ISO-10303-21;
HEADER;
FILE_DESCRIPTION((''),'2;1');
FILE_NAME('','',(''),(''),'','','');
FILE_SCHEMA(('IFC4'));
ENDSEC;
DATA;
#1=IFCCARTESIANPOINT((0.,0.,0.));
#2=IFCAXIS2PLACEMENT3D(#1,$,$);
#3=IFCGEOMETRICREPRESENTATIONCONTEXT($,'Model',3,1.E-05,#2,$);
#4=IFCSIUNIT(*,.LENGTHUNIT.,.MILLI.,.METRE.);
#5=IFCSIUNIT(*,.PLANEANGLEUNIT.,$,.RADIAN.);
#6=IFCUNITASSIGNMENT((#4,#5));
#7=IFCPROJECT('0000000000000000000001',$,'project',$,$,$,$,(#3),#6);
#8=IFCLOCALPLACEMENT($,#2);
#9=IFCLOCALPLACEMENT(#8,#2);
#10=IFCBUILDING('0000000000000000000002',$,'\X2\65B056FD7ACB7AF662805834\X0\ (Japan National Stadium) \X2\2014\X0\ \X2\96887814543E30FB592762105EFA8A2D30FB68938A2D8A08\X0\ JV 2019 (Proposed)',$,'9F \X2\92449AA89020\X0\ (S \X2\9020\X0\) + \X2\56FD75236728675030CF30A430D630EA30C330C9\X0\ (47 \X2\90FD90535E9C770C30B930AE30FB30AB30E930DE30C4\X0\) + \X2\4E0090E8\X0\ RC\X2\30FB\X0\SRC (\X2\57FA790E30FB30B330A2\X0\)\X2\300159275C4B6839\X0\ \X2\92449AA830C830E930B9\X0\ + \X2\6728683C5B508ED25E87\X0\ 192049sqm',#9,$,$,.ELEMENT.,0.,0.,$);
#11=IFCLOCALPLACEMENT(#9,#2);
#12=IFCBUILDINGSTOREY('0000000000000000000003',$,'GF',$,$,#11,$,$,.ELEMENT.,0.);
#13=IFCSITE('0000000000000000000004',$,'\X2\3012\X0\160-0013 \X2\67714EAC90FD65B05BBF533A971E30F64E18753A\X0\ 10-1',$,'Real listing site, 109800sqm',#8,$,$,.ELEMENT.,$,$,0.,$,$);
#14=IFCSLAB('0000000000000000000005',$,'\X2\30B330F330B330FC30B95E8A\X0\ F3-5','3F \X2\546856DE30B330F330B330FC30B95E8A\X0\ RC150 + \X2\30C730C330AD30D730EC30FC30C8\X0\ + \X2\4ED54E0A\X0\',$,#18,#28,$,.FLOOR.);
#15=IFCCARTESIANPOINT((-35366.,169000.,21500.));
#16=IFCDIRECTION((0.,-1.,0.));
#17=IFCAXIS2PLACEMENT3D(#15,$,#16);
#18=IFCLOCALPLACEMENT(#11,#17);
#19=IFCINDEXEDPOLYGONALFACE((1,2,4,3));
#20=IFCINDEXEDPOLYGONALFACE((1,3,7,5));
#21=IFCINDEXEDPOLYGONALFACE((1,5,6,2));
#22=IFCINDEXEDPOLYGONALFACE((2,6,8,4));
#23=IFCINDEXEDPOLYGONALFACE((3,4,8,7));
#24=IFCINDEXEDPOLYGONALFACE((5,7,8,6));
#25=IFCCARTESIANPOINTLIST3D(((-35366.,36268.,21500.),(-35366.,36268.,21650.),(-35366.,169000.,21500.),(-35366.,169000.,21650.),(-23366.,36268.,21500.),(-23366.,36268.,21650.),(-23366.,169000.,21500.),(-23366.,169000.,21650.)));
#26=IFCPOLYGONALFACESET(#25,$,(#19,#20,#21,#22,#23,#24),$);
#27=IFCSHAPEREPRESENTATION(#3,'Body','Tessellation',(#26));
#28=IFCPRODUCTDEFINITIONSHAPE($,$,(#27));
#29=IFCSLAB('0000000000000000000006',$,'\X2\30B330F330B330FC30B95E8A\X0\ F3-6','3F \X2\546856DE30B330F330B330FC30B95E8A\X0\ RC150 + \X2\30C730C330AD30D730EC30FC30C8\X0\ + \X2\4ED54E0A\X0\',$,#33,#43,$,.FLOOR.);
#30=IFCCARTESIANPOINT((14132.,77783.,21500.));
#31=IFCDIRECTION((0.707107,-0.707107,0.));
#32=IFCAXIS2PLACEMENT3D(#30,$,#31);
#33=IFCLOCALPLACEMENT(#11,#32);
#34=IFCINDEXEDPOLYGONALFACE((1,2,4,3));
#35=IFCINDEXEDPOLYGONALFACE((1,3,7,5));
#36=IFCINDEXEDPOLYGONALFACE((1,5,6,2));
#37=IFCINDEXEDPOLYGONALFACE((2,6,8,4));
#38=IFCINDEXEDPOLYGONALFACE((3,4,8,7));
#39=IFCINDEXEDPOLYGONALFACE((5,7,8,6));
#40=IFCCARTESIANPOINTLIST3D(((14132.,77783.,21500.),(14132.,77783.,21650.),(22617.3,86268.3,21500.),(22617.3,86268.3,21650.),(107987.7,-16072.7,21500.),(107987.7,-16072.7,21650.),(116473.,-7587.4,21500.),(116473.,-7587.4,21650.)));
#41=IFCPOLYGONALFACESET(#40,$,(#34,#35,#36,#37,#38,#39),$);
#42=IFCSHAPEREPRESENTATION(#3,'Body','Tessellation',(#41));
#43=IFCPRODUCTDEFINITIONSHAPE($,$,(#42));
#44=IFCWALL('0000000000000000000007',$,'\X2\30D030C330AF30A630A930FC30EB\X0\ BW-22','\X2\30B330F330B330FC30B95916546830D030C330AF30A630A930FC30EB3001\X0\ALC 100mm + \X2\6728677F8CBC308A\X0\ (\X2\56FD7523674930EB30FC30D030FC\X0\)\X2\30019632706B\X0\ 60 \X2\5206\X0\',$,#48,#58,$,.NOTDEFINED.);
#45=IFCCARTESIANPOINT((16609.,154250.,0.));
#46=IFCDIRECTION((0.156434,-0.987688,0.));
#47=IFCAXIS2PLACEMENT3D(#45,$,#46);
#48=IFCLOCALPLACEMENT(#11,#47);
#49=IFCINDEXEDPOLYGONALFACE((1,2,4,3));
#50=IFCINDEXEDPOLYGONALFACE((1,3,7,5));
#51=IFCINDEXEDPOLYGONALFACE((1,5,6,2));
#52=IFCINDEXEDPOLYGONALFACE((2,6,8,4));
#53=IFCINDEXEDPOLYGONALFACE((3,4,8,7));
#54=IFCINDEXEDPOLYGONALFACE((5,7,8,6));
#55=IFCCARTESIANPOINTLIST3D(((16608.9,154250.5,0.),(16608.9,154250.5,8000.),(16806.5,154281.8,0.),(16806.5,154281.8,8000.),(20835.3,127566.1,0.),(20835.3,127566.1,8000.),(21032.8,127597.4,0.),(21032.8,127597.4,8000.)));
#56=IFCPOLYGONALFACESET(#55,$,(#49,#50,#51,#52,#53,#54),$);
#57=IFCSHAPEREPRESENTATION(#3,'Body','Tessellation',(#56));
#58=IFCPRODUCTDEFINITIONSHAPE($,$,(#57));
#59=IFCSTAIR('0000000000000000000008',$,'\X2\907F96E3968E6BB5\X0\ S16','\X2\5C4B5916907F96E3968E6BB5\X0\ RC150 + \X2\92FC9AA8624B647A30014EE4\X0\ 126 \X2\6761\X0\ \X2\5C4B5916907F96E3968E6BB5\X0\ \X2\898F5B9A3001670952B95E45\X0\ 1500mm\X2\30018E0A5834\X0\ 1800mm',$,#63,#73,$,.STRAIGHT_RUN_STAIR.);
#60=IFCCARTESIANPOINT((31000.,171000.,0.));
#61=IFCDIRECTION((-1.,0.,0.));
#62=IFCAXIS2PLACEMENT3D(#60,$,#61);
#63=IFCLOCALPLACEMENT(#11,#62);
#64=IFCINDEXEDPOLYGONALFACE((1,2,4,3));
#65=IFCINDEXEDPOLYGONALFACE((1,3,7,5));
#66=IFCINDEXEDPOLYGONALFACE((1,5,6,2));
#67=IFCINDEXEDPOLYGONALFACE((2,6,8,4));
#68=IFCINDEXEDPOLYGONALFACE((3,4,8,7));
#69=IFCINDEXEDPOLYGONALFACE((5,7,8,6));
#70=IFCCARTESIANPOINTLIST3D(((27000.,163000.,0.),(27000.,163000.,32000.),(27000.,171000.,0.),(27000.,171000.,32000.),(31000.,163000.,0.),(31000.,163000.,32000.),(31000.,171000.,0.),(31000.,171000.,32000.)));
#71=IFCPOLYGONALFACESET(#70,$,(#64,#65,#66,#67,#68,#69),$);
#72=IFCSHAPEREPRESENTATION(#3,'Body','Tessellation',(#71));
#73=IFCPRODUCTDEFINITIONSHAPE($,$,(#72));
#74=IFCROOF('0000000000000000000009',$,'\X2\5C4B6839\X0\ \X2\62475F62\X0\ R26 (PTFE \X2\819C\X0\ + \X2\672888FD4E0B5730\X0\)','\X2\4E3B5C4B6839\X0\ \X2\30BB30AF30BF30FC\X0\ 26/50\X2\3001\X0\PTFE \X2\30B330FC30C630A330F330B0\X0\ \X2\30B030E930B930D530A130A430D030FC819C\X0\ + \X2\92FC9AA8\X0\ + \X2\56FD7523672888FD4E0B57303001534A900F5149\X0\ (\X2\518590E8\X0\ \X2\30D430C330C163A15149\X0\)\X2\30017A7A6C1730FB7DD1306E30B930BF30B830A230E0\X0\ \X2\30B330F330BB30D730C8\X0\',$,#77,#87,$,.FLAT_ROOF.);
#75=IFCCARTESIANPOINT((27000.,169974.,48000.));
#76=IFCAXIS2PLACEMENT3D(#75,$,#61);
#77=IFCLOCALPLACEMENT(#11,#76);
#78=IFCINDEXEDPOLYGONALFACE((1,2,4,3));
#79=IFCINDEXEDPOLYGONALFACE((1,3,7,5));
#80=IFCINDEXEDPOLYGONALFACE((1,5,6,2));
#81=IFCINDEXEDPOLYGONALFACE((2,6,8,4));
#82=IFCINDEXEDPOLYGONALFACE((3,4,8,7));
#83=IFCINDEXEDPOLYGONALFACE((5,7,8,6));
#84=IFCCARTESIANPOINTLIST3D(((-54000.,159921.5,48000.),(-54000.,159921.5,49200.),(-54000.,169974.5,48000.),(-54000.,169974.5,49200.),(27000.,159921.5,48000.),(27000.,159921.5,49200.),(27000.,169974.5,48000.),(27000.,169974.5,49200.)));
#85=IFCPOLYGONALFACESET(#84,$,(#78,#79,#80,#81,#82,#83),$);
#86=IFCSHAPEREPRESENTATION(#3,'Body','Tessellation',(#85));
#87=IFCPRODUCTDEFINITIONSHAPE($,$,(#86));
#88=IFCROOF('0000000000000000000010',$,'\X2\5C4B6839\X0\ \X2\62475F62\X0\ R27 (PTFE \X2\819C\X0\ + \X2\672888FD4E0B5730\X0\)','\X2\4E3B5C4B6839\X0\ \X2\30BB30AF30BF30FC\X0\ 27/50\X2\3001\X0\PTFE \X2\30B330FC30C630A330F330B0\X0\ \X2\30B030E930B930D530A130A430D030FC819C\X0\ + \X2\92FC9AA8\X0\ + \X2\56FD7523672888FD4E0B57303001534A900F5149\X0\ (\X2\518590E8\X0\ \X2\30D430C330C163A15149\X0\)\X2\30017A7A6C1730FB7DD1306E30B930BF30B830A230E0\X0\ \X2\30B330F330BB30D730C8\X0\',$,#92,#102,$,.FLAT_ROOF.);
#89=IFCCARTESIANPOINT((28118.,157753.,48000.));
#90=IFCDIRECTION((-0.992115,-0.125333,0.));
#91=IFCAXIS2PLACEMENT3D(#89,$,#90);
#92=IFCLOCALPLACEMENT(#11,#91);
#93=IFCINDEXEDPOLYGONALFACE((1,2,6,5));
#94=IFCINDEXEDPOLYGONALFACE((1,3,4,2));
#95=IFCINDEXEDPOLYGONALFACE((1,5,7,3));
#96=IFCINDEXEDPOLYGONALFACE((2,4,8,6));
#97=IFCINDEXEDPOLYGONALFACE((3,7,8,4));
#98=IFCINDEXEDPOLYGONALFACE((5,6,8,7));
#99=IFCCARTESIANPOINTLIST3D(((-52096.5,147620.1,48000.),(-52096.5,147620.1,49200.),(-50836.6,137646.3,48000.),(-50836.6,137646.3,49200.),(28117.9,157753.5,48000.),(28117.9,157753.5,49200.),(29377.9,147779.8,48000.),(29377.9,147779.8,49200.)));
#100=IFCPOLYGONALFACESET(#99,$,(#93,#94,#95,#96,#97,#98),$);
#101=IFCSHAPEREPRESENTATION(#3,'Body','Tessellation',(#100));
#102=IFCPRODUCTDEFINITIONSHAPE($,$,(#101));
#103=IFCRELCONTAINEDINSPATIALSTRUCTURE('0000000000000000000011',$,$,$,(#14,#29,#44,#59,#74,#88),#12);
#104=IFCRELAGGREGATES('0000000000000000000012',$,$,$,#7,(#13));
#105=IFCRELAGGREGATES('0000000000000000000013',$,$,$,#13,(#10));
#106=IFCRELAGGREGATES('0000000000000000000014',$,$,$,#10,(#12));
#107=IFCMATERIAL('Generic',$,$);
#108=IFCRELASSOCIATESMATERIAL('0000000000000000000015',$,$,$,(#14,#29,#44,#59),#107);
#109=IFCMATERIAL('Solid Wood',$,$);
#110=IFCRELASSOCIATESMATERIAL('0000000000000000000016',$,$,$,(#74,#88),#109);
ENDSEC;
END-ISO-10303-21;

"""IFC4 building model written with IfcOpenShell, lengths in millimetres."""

from ifc_helpers import new_model, si_unit, frame, frame_2d, origin, place, context, project, spatial, rectangle, extrude, material, element, save


model = new_model("IFC4")

# Units and contexts
model_context = context("Model", 3, precision=1e-05, world=origin())
ifc_project = project(units=[si_unit("LENGTHUNIT", "METRE", prefix="MILLI"), si_unit("PLANEANGLEUNIT", "RADIAN")], contexts=[model_context])

# Site, building, storey
site_placement = place(None, origin())
site = spatial("IfcSite", under=ifc_project, at=site_placement, Name="〒160-0013 東京都新宿区霞ヶ丘町 10-1", ObjectType="Real listing site, 109800sqm", CompositionType="ELEMENT", RefElevation=0.0)
building_placement = place(site_placement, origin())
building = spatial("IfcBuilding", under=site, at=building_placement, Name="新国立競技場 (Japan National Stadium) — 隈研吾・大成建設・梓設計 JV 2019 (Proposed)", ObjectType="9F 鉄骨造 (S 造) + 国産木材ハイブリッド (47 都道府県スギ・カラマツ) + 一部 RC・SRC (基礎・コア)、大屋根 鉄骨トラス + 木格子軒庇 192049sqm", CompositionType="ELEMENT", ElevationOfRefHeight=0.0, ElevationOfTerrain=0.0)
storey_placement = place(building_placement, origin())
storey = spatial("IfcBuildingStorey", under=building, at=storey_placement, Name="GF", CompositionType="ELEMENT", Elevation=0.0)

# Shared definitions
ifc_material_1 = material(Name="Generic")

# Shared definitions
ifc_material_2 = material(Name="Solid Wood")

# Slabs
slab_1_placement = place(storey_placement, frame((-35366.0, 169000.0, 21500.0), x_axis=(0.0, -1.0, 0.0)))
element("IfcSlab", 1, at=slab_1_placement, inside=storey, material=ifc_material_1, Name="コンコース床 F3-5", Description="3F 周回コンコース床 RC150 + デッキプレート + 仕上", PredefinedType="FLOOR", context=model_context, shape_type="SweptSolid", body=[
    extrude(rectangle(XDim=132732.0, YDim=12000.0, at=frame_2d((66366.0, 6000.0))), frame((-35366.0, 169000.0, 21500.0), x_axis=(0.0, -1.0, 0.0)), (0.0, 0.0, 1.0), 150.0),
])
slab_2_placement = place(storey_placement, frame((14132.0, 77783.0, 21500.0), x_axis=(0.707107, -0.707107, 0.0)))
element("IfcSlab", 2, at=slab_2_placement, inside=storey, material=ifc_material_1, Name="コンコース床 F3-6", Description="3F 周回コンコース床 RC150 + デッキプレート + 仕上", PredefinedType="FLOOR", context=model_context, shape_type="SweptSolid", body=[
    extrude(rectangle(XDim=132732.0, YDim=12000.0, at=frame_2d((66366.0, 6000.0))), frame((14132.0, 77783.0, 21500.0), x_axis=(0.707107, -0.707107, 0.0)), (0.0, 0.0, 1.0), 150.0),
])

# Wall
wall_1_placement = place(storey_placement, frame((16609.0, 154250.0, 0.0), x_axis=(0.156434, -0.987688, 0.0)))
element("IfcWall", 3, at=wall_1_placement, inside=storey, material=ifc_material_1, Name="バックウォール BW-22", Description="コンコース外周バックウォール、ALC 100mm + 木板貼り (国産杉ルーバー)、防火 60 分", PredefinedType="NOTDEFINED", context=model_context, shape_type="SweptSolid", body=[
    extrude(rectangle(XDim=27017.0, YDim=200.0, at=frame_2d((13508.0, 100.0))), frame((16609.0, 154250.0, 0.0), x_axis=(0.156434, -0.987688, 0.0)), (0.0, 0.0, 1.0), 8000.0),
])

# Stair
stair_placement = place(storey_placement, frame((31000.0, 171000.0, 0.0), x_axis=(-1.0, 0.0, 0.0)))
element("IfcStair", 4, at=stair_placement, inside=storey, material=ifc_material_1, Name="避難階段 S16", Description="屋外避難階段 RC150 + 鋼骨手摺、令 126 条 屋外避難階段 規定、有効幅 1500mm、踊場 1800mm", PredefinedType="STRAIGHT_RUN_STAIR", context=model_context, shape_type="SweptSolid", body=[
    extrude(rectangle(XDim=4000.0, YDim=8000.0, at=frame_2d((2000.0, 4000.0))), frame((31000.0, 171000.0, 0.0), x_axis=(-1.0, 0.0, 0.0)), (0.0, 0.0, 1.0), 32000.0),
])

# Roofs
roof_1_placement = place(storey_placement, frame((27000.0, 169974.0, 48000.0), x_axis=(-1.0, 0.0, 0.0)))
element("IfcRoof", 5, at=roof_1_placement, inside=storey, material=ifc_material_2, Name="屋根 扇形 R26 (PTFE 膜 + 木製下地)", Description="主屋根 セクター 26/50、PTFE コーティング グラスファイバー膜 + 鋼骨 + 国産木製下地、半透光 (内部 ピッチ採光)、空気・緑のスタジアム コンセプト", PredefinedType="FLAT_ROOF", context=model_context, shape_type="SweptSolid", body=[
    extrude(rectangle(XDim=81000.0, YDim=10053.0, at=frame_2d((40500.0, 5026.0))), frame((27000.0, 169974.0, 48000.0), x_axis=(-1.0, 0.0, 0.0)), (0.0, 0.0, 1.0), 1200.0),
])
roof_2_placement = place(storey_placement, frame((28118.0, 157753.0, 48000.0), x_axis=(-0.992115, -0.125333, 0.0)))
element("IfcRoof", 6, at=roof_2_placement, inside=storey, material=ifc_material_2, Name="屋根 扇形 R27 (PTFE 膜 + 木製下地)", Description="主屋根 セクター 27/50、PTFE コーティング グラスファイバー膜 + 鋼骨 + 国産木製下地、半透光 (内部 ピッチ採光)、空気・緑のスタジアム コンセプト", PredefinedType="FLAT_ROOF", context=model_context, shape_type="SweptSolid", body=[
    extrude(rectangle(XDim=80852.0, YDim=10053.0, at=frame_2d((40426.0, 5026.0))), frame((28118.0, 157753.0, 48000.0), x_axis=(-0.992115, -0.125333, 0.0)), (0.0, 0.0, 1.0), 1200.0),
])

save(model, "model.ifc")
